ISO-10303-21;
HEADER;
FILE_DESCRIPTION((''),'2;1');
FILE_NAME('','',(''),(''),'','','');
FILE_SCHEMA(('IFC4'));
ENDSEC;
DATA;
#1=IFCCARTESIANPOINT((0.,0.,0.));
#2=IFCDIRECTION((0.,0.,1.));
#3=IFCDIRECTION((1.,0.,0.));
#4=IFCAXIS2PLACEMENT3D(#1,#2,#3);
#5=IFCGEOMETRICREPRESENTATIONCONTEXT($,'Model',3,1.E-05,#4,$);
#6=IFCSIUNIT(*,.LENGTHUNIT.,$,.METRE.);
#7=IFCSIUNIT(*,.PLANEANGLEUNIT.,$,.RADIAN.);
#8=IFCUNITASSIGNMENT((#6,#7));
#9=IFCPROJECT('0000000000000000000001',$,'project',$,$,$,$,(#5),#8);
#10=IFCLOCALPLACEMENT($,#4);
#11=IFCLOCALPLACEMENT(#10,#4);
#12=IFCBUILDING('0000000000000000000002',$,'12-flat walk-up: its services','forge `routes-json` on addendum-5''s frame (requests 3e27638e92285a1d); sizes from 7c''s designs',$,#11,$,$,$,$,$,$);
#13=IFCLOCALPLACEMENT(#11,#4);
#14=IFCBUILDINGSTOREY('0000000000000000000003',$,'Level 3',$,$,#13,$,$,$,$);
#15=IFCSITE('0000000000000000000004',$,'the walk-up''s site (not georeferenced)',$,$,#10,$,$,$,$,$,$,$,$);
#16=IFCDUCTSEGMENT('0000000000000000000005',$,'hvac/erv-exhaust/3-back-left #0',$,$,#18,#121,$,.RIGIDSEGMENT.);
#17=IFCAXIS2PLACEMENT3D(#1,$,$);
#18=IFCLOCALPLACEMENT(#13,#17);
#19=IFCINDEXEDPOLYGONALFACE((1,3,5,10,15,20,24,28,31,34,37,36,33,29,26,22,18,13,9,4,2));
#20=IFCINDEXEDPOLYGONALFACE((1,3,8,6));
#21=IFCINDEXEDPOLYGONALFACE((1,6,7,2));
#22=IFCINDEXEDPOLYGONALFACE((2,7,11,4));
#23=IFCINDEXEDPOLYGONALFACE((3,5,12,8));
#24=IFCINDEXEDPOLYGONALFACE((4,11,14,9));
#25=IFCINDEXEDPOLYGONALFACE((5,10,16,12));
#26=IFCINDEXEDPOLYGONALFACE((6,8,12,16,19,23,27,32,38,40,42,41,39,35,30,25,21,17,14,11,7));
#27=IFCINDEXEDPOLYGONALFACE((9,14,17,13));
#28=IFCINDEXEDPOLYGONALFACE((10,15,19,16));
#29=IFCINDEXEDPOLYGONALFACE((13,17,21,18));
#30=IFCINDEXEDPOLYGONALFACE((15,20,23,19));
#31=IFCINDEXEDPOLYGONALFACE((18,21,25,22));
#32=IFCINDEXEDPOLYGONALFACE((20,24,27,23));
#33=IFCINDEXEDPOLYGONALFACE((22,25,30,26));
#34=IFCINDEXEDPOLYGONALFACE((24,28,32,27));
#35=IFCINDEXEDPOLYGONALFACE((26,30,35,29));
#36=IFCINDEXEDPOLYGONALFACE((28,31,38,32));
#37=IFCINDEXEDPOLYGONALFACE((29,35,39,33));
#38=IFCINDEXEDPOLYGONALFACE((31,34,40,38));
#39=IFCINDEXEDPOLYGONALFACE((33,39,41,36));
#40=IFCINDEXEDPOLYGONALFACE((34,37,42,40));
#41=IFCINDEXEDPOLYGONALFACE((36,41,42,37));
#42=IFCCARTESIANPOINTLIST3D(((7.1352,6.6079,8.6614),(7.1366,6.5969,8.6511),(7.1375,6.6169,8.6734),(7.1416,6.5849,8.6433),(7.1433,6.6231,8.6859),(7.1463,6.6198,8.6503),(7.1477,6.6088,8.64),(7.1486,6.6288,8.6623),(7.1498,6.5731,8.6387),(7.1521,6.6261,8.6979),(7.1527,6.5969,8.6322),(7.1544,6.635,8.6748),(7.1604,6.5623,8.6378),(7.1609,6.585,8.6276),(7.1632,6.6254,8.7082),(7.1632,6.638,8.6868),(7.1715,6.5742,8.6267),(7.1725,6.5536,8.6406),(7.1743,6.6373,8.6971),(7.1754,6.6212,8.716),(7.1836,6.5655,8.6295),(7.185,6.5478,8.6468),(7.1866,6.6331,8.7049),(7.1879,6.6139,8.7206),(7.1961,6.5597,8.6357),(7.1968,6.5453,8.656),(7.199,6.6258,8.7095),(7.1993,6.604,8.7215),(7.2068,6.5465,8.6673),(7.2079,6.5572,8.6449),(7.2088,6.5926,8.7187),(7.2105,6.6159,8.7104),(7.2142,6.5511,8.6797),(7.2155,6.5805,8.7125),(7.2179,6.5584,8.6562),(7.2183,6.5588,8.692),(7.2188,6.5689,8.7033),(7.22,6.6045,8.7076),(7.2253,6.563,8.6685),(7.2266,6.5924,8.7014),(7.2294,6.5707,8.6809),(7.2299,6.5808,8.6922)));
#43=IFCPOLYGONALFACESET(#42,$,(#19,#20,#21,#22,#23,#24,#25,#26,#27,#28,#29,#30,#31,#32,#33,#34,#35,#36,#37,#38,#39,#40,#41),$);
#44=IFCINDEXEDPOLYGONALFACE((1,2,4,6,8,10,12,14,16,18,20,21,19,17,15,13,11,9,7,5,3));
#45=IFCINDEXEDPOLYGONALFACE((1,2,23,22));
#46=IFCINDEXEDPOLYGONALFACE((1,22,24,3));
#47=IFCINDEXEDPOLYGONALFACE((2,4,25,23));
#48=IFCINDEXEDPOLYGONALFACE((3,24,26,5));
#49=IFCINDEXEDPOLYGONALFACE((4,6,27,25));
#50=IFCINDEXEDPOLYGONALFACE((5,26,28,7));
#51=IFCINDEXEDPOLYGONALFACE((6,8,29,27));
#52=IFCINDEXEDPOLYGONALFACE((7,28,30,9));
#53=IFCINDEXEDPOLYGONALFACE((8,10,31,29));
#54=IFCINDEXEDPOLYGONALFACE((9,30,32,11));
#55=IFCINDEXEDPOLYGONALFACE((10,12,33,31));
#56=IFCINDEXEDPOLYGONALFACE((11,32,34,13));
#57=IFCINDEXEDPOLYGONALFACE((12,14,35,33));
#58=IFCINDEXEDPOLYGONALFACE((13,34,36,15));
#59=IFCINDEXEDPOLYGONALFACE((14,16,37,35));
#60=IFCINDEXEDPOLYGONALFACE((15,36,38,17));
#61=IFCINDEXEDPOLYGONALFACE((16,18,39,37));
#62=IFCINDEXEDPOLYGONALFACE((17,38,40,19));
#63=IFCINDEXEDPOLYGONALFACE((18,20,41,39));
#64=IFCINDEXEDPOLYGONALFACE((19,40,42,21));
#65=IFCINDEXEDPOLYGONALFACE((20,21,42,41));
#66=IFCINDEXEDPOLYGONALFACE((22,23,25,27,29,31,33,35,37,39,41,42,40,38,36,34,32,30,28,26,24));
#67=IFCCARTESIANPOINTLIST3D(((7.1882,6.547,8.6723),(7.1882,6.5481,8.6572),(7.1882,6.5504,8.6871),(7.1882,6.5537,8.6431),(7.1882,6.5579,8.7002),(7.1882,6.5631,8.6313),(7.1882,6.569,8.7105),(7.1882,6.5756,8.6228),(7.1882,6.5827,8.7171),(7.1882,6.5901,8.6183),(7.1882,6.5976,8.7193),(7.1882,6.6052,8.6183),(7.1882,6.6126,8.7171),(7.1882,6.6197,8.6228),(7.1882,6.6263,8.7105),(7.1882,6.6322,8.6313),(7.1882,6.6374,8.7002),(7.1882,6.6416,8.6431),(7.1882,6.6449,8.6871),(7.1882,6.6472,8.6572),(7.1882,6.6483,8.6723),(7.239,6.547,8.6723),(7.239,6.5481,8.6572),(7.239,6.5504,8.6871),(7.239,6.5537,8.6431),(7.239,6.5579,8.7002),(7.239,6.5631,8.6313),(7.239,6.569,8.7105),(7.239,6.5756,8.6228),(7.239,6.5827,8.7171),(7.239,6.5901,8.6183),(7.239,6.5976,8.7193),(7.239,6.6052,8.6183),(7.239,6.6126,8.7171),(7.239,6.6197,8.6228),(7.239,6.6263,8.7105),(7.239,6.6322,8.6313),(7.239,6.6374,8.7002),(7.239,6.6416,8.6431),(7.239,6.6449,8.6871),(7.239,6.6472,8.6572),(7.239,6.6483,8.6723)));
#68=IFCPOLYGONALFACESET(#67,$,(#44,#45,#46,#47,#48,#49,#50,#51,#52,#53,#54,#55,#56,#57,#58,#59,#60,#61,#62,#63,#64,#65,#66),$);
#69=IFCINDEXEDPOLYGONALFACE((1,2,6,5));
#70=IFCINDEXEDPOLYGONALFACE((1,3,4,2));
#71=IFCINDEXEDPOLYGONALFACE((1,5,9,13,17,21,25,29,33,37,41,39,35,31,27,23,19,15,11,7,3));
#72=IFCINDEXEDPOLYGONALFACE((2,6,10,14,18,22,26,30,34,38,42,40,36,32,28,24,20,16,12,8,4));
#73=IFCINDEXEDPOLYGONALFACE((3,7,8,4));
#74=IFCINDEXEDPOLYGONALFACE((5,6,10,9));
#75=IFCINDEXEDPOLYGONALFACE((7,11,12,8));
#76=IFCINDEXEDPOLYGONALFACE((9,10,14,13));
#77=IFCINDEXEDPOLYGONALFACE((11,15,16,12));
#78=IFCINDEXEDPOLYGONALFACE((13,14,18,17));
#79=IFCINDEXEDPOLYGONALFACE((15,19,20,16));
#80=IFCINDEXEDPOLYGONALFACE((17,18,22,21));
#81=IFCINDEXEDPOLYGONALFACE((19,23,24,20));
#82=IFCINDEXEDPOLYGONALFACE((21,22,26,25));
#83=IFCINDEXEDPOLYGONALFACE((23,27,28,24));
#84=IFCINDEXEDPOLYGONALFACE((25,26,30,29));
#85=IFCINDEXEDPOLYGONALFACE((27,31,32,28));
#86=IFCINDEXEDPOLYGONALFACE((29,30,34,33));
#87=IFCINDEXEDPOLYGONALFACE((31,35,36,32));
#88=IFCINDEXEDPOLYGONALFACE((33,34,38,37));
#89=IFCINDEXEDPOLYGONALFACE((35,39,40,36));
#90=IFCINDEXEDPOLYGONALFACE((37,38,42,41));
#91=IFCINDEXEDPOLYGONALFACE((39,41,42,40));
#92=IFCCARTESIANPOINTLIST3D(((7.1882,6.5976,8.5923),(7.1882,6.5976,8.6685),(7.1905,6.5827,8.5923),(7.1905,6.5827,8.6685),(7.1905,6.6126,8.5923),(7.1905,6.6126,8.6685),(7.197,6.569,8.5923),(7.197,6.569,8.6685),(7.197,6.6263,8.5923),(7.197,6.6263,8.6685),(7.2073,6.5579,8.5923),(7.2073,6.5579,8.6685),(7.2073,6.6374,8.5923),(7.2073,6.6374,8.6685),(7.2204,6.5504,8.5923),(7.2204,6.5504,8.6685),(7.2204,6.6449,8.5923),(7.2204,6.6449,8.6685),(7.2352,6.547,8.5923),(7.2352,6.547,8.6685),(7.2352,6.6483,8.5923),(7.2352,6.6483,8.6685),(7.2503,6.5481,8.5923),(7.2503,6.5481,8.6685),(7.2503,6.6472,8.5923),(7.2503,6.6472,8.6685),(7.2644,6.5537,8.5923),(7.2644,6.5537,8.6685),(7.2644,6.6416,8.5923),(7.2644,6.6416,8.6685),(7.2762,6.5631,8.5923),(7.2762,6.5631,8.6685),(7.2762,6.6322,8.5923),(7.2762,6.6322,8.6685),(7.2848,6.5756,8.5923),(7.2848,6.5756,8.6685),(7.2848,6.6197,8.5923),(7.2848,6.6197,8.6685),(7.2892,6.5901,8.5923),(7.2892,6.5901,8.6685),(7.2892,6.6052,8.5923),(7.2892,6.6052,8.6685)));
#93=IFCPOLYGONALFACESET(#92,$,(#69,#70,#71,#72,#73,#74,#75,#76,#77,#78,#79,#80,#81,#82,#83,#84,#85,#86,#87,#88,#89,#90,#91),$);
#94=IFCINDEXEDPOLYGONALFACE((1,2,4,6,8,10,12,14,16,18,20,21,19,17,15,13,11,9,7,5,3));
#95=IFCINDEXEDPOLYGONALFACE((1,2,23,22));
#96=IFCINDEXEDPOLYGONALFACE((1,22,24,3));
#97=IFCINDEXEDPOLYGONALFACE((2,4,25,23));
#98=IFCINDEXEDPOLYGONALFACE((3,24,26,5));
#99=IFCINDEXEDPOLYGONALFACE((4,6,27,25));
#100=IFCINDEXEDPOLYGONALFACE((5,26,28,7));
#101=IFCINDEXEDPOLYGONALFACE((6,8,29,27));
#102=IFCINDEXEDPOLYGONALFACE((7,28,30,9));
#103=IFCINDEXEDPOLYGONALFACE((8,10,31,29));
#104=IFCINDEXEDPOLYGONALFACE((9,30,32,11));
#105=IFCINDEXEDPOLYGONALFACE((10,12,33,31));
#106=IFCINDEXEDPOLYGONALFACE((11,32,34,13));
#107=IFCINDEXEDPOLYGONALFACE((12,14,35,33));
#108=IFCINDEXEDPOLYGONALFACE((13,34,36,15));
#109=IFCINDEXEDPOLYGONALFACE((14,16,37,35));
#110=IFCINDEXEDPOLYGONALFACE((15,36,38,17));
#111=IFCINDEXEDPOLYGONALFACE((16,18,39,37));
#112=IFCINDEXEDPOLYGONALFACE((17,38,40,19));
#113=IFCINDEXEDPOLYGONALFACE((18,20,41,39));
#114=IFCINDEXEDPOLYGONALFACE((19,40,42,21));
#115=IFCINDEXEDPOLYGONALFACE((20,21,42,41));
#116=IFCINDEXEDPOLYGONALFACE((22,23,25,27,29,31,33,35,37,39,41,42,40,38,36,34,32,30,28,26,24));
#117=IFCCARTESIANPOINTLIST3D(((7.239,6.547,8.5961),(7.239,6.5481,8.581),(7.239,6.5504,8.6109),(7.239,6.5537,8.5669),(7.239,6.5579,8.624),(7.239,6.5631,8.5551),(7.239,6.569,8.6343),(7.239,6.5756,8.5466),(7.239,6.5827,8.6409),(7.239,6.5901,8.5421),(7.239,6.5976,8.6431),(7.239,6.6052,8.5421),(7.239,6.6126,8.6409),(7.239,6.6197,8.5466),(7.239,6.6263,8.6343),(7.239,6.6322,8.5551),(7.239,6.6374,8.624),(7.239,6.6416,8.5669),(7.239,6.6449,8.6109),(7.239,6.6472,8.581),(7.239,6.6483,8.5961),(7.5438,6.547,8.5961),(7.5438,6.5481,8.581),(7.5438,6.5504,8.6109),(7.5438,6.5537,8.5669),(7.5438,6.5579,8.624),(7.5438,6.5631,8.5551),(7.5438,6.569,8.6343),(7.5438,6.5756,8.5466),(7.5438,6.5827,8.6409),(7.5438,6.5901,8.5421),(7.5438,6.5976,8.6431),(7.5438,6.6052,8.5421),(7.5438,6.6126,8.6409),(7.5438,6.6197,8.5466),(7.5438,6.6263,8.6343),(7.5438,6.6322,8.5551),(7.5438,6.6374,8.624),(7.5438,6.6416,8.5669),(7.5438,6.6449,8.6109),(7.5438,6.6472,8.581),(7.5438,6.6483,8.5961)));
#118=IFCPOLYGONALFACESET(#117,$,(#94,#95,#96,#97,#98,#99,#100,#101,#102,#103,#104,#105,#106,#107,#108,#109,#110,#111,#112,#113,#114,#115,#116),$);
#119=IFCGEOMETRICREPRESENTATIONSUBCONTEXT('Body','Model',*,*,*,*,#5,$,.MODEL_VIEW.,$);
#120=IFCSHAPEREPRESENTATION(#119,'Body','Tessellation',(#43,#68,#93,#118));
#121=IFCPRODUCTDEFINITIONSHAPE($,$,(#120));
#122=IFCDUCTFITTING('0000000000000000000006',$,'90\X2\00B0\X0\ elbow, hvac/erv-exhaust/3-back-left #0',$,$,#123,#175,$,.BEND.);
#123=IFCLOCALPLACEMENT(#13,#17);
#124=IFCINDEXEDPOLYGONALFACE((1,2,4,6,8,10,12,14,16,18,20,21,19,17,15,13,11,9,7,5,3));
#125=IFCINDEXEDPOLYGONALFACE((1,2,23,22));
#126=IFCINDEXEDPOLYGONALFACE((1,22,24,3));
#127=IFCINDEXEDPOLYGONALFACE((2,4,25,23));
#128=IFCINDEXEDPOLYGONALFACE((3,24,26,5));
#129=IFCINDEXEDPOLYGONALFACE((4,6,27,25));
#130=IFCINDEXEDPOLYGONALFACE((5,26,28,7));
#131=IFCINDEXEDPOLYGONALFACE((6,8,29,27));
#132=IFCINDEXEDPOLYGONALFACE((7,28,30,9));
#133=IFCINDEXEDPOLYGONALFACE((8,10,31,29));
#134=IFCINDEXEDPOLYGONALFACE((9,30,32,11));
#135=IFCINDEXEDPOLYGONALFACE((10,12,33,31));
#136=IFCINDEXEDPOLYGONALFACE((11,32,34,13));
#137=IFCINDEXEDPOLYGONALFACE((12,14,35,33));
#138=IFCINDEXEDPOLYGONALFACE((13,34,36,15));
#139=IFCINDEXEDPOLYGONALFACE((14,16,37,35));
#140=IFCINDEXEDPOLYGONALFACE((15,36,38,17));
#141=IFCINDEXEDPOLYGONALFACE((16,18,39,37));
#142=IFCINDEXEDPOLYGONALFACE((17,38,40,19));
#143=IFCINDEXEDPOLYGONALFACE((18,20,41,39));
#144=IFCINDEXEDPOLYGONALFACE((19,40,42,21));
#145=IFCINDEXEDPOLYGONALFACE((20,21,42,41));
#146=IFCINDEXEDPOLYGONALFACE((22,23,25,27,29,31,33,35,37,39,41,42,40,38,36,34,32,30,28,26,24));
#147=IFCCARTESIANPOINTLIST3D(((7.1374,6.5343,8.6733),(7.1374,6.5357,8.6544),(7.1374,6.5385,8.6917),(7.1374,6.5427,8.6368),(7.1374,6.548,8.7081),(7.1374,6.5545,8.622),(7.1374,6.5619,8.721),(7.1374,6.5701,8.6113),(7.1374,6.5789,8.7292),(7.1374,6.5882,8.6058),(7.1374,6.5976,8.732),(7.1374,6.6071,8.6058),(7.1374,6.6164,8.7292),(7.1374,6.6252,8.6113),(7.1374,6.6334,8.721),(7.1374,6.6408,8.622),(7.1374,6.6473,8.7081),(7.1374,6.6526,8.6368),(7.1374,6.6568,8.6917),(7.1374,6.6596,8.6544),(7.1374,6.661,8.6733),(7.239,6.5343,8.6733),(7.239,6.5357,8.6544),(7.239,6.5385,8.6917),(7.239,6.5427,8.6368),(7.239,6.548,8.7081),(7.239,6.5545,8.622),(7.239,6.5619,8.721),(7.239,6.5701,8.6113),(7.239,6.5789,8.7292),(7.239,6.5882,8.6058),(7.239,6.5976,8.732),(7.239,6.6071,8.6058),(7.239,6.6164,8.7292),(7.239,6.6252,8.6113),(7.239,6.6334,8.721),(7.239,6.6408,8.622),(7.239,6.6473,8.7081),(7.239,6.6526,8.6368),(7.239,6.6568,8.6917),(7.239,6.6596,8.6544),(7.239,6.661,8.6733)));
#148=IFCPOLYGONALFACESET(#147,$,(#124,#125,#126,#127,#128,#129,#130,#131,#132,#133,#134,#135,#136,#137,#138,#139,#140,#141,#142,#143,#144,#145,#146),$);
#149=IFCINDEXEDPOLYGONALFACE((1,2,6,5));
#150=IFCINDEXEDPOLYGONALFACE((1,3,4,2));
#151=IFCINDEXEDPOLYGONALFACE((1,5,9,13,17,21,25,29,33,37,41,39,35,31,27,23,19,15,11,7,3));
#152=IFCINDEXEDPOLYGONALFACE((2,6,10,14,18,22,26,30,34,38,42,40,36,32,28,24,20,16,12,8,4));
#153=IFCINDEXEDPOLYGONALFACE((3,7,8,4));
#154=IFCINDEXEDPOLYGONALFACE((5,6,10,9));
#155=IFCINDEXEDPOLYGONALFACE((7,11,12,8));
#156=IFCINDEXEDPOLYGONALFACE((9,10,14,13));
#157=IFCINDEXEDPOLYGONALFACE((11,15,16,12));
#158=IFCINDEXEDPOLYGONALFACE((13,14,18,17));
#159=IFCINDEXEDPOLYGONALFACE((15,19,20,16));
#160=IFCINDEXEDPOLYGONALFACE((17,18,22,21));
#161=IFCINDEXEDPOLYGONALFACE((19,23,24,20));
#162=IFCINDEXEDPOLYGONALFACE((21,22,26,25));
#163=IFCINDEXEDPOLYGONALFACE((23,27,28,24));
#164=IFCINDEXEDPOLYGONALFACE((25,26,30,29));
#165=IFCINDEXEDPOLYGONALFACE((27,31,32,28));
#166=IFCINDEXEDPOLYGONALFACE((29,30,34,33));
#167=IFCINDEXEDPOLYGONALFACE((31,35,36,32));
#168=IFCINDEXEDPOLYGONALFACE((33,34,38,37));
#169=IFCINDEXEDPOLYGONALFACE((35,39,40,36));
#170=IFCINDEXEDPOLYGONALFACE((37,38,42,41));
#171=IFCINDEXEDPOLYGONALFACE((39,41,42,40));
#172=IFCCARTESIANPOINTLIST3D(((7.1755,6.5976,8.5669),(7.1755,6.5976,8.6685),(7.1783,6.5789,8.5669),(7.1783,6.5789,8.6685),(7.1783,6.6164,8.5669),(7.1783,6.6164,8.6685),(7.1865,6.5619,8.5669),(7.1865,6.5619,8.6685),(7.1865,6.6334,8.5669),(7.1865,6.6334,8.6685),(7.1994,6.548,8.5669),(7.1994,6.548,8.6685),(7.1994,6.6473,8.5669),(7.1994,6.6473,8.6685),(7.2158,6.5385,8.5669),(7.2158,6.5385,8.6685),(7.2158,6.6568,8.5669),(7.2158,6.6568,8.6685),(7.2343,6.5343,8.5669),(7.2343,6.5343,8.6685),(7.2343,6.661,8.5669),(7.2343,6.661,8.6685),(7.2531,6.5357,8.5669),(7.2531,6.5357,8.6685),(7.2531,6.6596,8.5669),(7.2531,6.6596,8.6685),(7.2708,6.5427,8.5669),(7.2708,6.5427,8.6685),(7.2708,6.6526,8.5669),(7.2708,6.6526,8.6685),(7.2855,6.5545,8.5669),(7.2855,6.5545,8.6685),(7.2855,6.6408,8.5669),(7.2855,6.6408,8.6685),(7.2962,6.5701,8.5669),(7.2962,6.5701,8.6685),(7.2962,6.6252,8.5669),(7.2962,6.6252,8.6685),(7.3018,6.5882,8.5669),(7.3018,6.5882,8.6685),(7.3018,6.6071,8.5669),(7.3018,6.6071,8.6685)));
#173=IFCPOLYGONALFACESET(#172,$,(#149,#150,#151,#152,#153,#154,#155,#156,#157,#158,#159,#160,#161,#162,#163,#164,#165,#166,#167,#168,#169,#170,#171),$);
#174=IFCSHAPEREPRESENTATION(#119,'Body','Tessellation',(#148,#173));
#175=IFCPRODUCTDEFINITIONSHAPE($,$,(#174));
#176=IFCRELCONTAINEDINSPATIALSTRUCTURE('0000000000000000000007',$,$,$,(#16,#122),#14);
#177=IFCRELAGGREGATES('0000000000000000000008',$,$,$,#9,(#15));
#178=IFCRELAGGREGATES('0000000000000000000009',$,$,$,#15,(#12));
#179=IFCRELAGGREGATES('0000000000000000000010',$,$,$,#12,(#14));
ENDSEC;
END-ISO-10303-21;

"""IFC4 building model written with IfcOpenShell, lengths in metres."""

from ifc_helpers import new_model, entity, si_unit, frame, origin_with_axes, place, context, subcontext, project, spatial, element, save


model = new_model("IFC4")

# Units and contexts
model_context = context("Model", 3, precision=1e-05, world=origin_with_axes())
body_context = subcontext(model_context, "Body", "Model", "MODEL_VIEW")
ifc_project = project(units=[si_unit("LENGTHUNIT", "METRE"), si_unit("PLANEANGLEUNIT", "RADIAN")], contexts=[model_context])

# Site, building, storey
site_placement = place(None, origin_with_axes())
site = spatial("IfcSite", under=ifc_project, at=site_placement, Name="the walk-up's site (not georeferenced)")
building_placement = place(site_placement, origin_with_axes())
building = spatial("IfcBuilding", under=site, at=building_placement, Name="12-flat walk-up: its services", Description="forge `routes-json` on addendum-5's frame (requests 3e27638e92285a1d); sizes from 7c's designs")
storey_placement = place(building_placement, origin_with_axes())
storey = spatial("IfcBuildingStorey", under=building, at=storey_placement, Name="Level 3")

# Duct segment
duct_segment_1_placement = place(storey_placement, frame((7.1771, 6.5857, 8.6797), z_axis=(0.0, 0.0, 1.0), x_axis=(1.0, 0.0, 0.0)))
element("IfcDuctSegment", 1, at=duct_segment_1_placement, inside=storey, Name="hvac/erv-exhaust/3-back-left #0", PredefinedType="RIGIDSEGMENT", context=body_context, shape_type="AdvancedSweptSolid", body=[
    entity("IfcSweptDiskSolid", entity("IfcPolyline", [entity("IfcCartesianPoint", [0.0, 0.0, 0.0]), entity("IfcCartesianPoint", [0.0111, 0.0119, -0.0111])]), 0.0508),
    entity("IfcSweptDiskSolid", entity("IfcPolyline", [entity("IfcCartesianPoint", [0.0111, 0.0119, -0.0111]), entity("IfcCartesianPoint", [0.0619, 0.0119, -0.0111])]), 0.0508),
    entity("IfcSweptDiskSolid", entity("IfcPolyline", [entity("IfcCartesianPoint", [0.0619, 0.0119, -0.0111]), entity("IfcCartesianPoint", [0.0619, 0.0119, -0.0873])]), 0.0508),
    entity("IfcSweptDiskSolid", entity("IfcPolyline", [entity("IfcCartesianPoint", [0.0619, 0.0119, -0.0873]), entity("IfcCartesianPoint", [0.3667, 0.0119, -0.0873])]), 0.0508),
])

# Duct fitting
duct_fitting_1_placement = place(storey_placement, frame((7.1374, 6.5976, 8.6685), z_axis=(0.0, 0.0, 1.0), x_axis=(1.0, 0.0, 0.0)))
element("IfcDuctFitting", 2, at=duct_fitting_1_placement, inside=storey, Name="90° elbow, hvac/erv-exhaust/3-back-left #0", PredefinedType="BEND", context=body_context, shape_type="AdvancedSweptSolid", body=[
    entity("IfcSweptDiskSolid", entity("IfcPolyline", [entity("IfcCartesianPoint", [0.0, 0.0, 0.0]), entity("IfcCartesianPoint", [0.1016, 0.0, 0.0])]), 0.0635),
    entity("IfcSweptDiskSolid", entity("IfcPolyline", [entity("IfcCartesianPoint", [0.1016, 0.0, 0.0]), entity("IfcCartesianPoint", [0.1016, 0.0, -0.1016])]), 0.0635),
])

save(model, "model.ifc")
